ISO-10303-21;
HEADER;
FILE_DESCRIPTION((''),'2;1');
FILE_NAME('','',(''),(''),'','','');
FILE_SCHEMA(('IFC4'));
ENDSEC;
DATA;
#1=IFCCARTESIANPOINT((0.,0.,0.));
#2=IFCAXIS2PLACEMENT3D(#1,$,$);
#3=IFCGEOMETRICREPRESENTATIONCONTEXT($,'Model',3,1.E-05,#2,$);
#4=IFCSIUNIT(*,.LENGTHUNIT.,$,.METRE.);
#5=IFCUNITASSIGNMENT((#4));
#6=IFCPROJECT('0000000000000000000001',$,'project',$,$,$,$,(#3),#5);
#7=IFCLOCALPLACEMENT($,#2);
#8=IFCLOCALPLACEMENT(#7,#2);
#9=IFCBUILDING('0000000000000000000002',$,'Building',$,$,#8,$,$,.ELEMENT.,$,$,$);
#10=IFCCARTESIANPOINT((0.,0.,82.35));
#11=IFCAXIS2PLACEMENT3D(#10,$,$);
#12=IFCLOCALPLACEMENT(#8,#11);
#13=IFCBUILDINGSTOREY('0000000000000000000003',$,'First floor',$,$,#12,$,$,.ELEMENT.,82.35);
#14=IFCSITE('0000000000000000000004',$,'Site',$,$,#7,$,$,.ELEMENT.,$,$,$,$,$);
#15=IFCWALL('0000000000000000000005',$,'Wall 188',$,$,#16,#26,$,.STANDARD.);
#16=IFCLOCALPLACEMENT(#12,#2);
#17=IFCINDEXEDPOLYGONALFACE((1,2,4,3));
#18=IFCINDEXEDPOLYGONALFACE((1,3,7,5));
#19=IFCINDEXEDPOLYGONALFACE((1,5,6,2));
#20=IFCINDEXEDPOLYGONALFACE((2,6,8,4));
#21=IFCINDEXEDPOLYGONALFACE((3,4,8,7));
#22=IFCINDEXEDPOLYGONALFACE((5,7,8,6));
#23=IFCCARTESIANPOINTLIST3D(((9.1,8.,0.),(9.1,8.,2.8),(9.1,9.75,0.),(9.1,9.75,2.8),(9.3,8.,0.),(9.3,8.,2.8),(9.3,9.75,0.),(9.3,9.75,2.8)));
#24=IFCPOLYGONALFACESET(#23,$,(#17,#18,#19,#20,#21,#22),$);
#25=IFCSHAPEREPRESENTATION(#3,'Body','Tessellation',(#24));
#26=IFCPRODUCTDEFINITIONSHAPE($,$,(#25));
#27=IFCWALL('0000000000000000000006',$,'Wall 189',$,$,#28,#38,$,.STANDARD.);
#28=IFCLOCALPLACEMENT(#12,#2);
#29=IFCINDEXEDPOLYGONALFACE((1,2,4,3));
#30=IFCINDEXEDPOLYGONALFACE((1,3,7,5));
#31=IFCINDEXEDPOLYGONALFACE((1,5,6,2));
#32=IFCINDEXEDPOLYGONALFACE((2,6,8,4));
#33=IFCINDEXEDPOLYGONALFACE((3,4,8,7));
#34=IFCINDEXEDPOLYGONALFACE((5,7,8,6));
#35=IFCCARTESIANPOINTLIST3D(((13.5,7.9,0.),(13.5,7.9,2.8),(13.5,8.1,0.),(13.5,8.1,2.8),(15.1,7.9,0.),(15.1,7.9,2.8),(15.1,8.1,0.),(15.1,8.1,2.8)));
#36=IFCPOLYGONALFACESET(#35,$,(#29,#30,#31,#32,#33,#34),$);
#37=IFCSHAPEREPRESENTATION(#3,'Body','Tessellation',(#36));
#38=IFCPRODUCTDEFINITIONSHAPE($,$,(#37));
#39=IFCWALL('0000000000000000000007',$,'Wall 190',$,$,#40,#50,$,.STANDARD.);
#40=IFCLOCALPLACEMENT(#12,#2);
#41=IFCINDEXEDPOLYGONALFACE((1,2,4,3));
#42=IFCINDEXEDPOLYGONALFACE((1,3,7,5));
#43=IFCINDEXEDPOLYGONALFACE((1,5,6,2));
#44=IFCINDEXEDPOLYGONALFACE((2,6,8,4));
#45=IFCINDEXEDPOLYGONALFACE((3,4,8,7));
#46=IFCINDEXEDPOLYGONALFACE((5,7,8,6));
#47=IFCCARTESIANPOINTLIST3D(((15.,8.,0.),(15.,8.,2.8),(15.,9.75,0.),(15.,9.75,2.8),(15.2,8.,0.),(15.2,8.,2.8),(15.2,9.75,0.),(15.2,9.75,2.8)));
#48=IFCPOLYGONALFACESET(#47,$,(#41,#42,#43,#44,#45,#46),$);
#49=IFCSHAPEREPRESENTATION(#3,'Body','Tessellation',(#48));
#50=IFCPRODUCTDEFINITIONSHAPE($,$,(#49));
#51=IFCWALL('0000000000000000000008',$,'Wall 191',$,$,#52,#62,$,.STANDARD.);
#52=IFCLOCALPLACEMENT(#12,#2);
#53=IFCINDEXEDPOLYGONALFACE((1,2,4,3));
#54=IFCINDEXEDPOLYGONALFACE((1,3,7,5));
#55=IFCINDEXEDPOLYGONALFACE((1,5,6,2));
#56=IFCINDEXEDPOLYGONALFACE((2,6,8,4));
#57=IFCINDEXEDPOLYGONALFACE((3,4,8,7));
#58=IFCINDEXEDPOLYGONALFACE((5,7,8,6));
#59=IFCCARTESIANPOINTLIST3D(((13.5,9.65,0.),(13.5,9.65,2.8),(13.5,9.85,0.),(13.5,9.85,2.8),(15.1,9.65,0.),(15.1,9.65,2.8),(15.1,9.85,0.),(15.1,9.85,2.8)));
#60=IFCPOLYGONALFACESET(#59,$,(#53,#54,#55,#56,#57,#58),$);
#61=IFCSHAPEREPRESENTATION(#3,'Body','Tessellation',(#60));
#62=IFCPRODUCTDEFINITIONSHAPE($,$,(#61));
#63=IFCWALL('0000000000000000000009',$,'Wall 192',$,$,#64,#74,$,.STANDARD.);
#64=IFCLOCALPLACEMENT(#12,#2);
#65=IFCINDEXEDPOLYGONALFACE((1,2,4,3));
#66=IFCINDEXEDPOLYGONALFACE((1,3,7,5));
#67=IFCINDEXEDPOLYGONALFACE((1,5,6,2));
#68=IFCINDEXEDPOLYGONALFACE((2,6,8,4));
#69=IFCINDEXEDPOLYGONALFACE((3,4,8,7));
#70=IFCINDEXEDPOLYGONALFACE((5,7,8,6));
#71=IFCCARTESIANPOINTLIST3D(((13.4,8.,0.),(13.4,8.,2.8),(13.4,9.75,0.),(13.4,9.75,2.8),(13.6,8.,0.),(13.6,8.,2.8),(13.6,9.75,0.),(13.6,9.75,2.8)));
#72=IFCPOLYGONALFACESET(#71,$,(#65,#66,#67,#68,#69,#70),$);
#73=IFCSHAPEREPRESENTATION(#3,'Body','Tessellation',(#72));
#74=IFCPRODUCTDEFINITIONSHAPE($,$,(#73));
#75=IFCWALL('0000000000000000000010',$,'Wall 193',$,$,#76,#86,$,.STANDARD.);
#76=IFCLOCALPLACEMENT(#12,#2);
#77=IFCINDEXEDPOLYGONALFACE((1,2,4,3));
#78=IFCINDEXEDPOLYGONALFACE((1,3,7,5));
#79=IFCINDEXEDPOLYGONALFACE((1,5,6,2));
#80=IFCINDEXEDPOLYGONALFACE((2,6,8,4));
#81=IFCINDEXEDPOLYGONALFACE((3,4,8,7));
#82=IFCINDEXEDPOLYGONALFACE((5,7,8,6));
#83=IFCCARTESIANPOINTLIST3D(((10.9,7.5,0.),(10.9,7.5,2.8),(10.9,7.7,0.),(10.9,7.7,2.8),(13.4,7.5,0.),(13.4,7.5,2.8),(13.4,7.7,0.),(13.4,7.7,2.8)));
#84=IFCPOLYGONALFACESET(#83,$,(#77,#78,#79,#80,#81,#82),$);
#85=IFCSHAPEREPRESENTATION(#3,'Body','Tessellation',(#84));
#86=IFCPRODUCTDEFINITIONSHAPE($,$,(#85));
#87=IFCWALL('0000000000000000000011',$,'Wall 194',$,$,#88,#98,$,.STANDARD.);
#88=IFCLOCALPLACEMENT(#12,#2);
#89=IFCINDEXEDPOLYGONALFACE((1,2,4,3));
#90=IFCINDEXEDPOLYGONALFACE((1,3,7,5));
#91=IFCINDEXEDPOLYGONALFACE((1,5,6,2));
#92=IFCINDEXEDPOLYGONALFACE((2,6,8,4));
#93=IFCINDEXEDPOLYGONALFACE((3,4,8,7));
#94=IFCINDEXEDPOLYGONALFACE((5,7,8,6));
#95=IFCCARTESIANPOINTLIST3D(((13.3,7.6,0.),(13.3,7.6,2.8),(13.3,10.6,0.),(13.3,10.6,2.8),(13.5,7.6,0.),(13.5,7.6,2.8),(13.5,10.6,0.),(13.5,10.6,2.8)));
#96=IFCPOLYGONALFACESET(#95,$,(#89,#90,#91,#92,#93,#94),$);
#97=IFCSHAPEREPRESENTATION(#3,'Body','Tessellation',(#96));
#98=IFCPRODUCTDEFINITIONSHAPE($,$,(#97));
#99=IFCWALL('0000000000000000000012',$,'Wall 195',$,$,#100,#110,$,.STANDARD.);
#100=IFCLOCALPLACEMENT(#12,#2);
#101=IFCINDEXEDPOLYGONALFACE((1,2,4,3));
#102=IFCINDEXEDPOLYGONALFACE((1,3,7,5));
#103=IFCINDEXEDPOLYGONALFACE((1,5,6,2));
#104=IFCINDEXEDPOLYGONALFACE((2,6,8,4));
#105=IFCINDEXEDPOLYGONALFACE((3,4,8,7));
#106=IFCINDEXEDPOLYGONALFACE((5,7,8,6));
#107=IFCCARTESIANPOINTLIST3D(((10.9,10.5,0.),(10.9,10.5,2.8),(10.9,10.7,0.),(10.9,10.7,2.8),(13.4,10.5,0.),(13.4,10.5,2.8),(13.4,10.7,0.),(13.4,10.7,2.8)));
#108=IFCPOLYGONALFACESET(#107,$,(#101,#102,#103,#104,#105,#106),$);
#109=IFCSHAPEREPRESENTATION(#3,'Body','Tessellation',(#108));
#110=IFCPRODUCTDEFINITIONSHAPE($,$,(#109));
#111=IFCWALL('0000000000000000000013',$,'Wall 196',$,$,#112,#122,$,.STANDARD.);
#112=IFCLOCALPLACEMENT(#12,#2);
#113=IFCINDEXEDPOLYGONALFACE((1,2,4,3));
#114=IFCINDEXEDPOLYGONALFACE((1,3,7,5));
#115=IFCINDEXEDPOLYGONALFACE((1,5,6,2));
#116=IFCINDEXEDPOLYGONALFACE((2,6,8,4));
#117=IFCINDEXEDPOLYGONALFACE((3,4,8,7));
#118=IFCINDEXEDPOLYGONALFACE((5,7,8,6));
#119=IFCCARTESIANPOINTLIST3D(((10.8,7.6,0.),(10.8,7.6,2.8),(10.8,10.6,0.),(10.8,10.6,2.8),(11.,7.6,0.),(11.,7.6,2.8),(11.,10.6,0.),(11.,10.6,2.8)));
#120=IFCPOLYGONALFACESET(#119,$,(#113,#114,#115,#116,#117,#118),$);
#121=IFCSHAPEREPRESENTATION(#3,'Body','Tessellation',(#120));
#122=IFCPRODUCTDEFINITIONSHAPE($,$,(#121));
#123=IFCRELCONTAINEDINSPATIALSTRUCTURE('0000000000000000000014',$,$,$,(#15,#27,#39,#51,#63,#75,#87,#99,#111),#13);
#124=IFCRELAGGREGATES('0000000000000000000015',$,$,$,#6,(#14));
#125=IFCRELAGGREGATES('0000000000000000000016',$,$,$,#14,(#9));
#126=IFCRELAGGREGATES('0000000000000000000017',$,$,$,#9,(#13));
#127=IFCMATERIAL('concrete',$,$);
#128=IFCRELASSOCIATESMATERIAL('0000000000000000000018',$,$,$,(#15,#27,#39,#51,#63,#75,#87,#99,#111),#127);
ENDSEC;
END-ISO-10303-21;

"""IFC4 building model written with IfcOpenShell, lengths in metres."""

from ifc_helpers import new_model, si_unit, frame, frame_2d, origin, place, context, project, spatial, rectangle, extrude, material, element, save


model = new_model("IFC4")

# Units and contexts
model_context = context("Model", 3, precision=1e-05, world=origin())
ifc_project = project(units=[si_unit("LENGTHUNIT", "METRE")], contexts=[model_context])

# Site, building, storey
site_placement = place(None, origin())
site = spatial("IfcSite", under=ifc_project, at=site_placement, Name="Site", CompositionType="ELEMENT")
building_placement = place(site_placement, origin())
building = spatial("IfcBuilding", under=site, at=building_placement, Name="Building", CompositionType="ELEMENT")
storey_placement = place(building_placement, frame((0.0, 0.0, 82.35)))
storey = spatial("IfcBuildingStorey", under=building, at=storey_placement, Name="First floor", CompositionType="ELEMENT", Elevation=82.35)

# Shared definitions
ifc_material = material(Name="concrete")

# Walls
wall_1_placement = place(storey_placement, frame((9.2, 9.75, 0.0), z_axis=(0.0, 0.0, 1.0), x_axis=(0.0, -1.0, 0.0)))
element("IfcWall", 1, at=wall_1_placement, inside=storey, material=ifc_material, Name="Wall 188", PredefinedType="STANDARD", context=model_context, shape_type="SweptSolid", body=[
    extrude(rectangle(XDim=1.75, YDim=0.2, at=frame_2d((0.875, 0.0))), origin(), (0.0, 0.0, 1.0), 2.8),
])
wall_2_placement = place(storey_placement, frame((13.5, 8.0, 0.0), z_axis=(0.0, 0.0, 1.0), x_axis=(1.0, 0.0, 0.0)))
element("IfcWall", 2, at=wall_2_placement, inside=storey, material=ifc_material, Name="Wall 189", PredefinedType="STANDARD", context=model_context, shape_type="SweptSolid", body=[
    extrude(rectangle(XDim=1.6, YDim=0.2, at=frame_2d((0.8, 0.0))), origin(), (0.0, 0.0, 1.0), 2.8),
])
wall_3_placement = place(storey_placement, frame((15.1, 8.0, 0.0), z_axis=(0.0, 0.0, 1.0), x_axis=(0.0, 1.0, 0.0)))
element("IfcWall", 3, at=wall_3_placement, inside=storey, material=ifc_material, Name="Wall 190", PredefinedType="STANDARD", context=model_context, shape_type="SweptSolid", body=[
    extrude(rectangle(XDim=1.75, YDim=0.2, at=frame_2d((0.875, 0.0))), origin(), (0.0, 0.0, 1.0), 2.8),
])
wall_4_placement = place(storey_placement, frame((15.1, 9.75, 0.0), z_axis=(0.0, 0.0, 1.0), x_axis=(-1.0, 0.0, 0.0)))
element("IfcWall", 4, at=wall_4_placement, inside=storey, material=ifc_material, Name="Wall 191", PredefinedType="STANDARD", context=model_context, shape_type="SweptSolid", body=[
    extrude(rectangle(XDim=1.6, YDim=0.2, at=frame_2d((0.8, 0.0))), origin(), (0.0, 0.0, 1.0), 2.8),
])
wall_5_placement = place(storey_placement, frame((13.5, 9.75, 0.0), z_axis=(0.0, 0.0, 1.0), x_axis=(0.0, -1.0, 0.0)))
element("IfcWall", 5, at=wall_5_placement, inside=storey, material=ifc_material, Name="Wall 192", PredefinedType="STANDARD", context=model_context, shape_type="SweptSolid", body=[
    extrude(rectangle(XDim=1.75, YDim=0.2, at=frame_2d((0.875, 0.0))), origin(), (0.0, 0.0, 1.0), 2.8),
])
wall_6_placement = place(storey_placement, frame((10.9, 7.6, 0.0), z_axis=(0.0, 0.0, 1.0), x_axis=(1.0, 0.0, 0.0)))
element("IfcWall", 6, at=wall_6_placement, inside=storey, material=ifc_material, Name="Wall 193", PredefinedType="STANDARD", context=model_context, shape_type="SweptSolid", body=[
    extrude(rectangle(XDim=2.5, YDim=0.2, at=frame_2d((1.25, 0.0))), origin(), (0.0, 0.0, 1.0), 2.8),
])
wall_7_placement = place(storey_placement, frame((13.4, 7.6, 0.0), z_axis=(0.0, 0.0, 1.0), x_axis=(0.0, 1.0, 0.0)))
element("IfcWall", 7, at=wall_7_placement, inside=storey, material=ifc_material, Name="Wall 194", PredefinedType="STANDARD", context=model_context, shape_type="SweptSolid", body=[
    extrude(rectangle(XDim=3.0, YDim=0.2, at=frame_2d((1.5, 0.0))), origin(), (0.0, 0.0, 1.0), 2.8),
])
wall_8_placement = place(storey_placement, frame((13.4, 10.6, 0.0), z_axis=(0.0, 0.0, 1.0), x_axis=(-1.0, 0.0, 0.0)))
element("IfcWall", 8, at=wall_8_placement, inside=storey, material=ifc_material, Name="Wall 195", PredefinedType="STANDARD", context=model_context, shape_type="SweptSolid", body=[
    extrude(rectangle(XDim=2.5, YDim=0.2, at=frame_2d((1.25, 0.0))), origin(), (0.0, 0.0, 1.0), 2.8),
])
wall_9_placement = place(storey_placement, frame((10.9, 10.6, 0.0), z_axis=(0.0, 0.0, 1.0), x_axis=(0.0, -1.0, 0.0)))
element("IfcWall", 9, at=wall_9_placement, inside=storey, material=ifc_material, Name="Wall 196", PredefinedType="STANDARD", context=model_context, shape_type="SweptSolid", body=[
    extrude(rectangle(XDim=3.0, YDim=0.2, at=frame_2d((1.5, 0.0))), origin(), (0.0, 0.0, 1.0), 2.8),
])

save(model, "model.ifc")
